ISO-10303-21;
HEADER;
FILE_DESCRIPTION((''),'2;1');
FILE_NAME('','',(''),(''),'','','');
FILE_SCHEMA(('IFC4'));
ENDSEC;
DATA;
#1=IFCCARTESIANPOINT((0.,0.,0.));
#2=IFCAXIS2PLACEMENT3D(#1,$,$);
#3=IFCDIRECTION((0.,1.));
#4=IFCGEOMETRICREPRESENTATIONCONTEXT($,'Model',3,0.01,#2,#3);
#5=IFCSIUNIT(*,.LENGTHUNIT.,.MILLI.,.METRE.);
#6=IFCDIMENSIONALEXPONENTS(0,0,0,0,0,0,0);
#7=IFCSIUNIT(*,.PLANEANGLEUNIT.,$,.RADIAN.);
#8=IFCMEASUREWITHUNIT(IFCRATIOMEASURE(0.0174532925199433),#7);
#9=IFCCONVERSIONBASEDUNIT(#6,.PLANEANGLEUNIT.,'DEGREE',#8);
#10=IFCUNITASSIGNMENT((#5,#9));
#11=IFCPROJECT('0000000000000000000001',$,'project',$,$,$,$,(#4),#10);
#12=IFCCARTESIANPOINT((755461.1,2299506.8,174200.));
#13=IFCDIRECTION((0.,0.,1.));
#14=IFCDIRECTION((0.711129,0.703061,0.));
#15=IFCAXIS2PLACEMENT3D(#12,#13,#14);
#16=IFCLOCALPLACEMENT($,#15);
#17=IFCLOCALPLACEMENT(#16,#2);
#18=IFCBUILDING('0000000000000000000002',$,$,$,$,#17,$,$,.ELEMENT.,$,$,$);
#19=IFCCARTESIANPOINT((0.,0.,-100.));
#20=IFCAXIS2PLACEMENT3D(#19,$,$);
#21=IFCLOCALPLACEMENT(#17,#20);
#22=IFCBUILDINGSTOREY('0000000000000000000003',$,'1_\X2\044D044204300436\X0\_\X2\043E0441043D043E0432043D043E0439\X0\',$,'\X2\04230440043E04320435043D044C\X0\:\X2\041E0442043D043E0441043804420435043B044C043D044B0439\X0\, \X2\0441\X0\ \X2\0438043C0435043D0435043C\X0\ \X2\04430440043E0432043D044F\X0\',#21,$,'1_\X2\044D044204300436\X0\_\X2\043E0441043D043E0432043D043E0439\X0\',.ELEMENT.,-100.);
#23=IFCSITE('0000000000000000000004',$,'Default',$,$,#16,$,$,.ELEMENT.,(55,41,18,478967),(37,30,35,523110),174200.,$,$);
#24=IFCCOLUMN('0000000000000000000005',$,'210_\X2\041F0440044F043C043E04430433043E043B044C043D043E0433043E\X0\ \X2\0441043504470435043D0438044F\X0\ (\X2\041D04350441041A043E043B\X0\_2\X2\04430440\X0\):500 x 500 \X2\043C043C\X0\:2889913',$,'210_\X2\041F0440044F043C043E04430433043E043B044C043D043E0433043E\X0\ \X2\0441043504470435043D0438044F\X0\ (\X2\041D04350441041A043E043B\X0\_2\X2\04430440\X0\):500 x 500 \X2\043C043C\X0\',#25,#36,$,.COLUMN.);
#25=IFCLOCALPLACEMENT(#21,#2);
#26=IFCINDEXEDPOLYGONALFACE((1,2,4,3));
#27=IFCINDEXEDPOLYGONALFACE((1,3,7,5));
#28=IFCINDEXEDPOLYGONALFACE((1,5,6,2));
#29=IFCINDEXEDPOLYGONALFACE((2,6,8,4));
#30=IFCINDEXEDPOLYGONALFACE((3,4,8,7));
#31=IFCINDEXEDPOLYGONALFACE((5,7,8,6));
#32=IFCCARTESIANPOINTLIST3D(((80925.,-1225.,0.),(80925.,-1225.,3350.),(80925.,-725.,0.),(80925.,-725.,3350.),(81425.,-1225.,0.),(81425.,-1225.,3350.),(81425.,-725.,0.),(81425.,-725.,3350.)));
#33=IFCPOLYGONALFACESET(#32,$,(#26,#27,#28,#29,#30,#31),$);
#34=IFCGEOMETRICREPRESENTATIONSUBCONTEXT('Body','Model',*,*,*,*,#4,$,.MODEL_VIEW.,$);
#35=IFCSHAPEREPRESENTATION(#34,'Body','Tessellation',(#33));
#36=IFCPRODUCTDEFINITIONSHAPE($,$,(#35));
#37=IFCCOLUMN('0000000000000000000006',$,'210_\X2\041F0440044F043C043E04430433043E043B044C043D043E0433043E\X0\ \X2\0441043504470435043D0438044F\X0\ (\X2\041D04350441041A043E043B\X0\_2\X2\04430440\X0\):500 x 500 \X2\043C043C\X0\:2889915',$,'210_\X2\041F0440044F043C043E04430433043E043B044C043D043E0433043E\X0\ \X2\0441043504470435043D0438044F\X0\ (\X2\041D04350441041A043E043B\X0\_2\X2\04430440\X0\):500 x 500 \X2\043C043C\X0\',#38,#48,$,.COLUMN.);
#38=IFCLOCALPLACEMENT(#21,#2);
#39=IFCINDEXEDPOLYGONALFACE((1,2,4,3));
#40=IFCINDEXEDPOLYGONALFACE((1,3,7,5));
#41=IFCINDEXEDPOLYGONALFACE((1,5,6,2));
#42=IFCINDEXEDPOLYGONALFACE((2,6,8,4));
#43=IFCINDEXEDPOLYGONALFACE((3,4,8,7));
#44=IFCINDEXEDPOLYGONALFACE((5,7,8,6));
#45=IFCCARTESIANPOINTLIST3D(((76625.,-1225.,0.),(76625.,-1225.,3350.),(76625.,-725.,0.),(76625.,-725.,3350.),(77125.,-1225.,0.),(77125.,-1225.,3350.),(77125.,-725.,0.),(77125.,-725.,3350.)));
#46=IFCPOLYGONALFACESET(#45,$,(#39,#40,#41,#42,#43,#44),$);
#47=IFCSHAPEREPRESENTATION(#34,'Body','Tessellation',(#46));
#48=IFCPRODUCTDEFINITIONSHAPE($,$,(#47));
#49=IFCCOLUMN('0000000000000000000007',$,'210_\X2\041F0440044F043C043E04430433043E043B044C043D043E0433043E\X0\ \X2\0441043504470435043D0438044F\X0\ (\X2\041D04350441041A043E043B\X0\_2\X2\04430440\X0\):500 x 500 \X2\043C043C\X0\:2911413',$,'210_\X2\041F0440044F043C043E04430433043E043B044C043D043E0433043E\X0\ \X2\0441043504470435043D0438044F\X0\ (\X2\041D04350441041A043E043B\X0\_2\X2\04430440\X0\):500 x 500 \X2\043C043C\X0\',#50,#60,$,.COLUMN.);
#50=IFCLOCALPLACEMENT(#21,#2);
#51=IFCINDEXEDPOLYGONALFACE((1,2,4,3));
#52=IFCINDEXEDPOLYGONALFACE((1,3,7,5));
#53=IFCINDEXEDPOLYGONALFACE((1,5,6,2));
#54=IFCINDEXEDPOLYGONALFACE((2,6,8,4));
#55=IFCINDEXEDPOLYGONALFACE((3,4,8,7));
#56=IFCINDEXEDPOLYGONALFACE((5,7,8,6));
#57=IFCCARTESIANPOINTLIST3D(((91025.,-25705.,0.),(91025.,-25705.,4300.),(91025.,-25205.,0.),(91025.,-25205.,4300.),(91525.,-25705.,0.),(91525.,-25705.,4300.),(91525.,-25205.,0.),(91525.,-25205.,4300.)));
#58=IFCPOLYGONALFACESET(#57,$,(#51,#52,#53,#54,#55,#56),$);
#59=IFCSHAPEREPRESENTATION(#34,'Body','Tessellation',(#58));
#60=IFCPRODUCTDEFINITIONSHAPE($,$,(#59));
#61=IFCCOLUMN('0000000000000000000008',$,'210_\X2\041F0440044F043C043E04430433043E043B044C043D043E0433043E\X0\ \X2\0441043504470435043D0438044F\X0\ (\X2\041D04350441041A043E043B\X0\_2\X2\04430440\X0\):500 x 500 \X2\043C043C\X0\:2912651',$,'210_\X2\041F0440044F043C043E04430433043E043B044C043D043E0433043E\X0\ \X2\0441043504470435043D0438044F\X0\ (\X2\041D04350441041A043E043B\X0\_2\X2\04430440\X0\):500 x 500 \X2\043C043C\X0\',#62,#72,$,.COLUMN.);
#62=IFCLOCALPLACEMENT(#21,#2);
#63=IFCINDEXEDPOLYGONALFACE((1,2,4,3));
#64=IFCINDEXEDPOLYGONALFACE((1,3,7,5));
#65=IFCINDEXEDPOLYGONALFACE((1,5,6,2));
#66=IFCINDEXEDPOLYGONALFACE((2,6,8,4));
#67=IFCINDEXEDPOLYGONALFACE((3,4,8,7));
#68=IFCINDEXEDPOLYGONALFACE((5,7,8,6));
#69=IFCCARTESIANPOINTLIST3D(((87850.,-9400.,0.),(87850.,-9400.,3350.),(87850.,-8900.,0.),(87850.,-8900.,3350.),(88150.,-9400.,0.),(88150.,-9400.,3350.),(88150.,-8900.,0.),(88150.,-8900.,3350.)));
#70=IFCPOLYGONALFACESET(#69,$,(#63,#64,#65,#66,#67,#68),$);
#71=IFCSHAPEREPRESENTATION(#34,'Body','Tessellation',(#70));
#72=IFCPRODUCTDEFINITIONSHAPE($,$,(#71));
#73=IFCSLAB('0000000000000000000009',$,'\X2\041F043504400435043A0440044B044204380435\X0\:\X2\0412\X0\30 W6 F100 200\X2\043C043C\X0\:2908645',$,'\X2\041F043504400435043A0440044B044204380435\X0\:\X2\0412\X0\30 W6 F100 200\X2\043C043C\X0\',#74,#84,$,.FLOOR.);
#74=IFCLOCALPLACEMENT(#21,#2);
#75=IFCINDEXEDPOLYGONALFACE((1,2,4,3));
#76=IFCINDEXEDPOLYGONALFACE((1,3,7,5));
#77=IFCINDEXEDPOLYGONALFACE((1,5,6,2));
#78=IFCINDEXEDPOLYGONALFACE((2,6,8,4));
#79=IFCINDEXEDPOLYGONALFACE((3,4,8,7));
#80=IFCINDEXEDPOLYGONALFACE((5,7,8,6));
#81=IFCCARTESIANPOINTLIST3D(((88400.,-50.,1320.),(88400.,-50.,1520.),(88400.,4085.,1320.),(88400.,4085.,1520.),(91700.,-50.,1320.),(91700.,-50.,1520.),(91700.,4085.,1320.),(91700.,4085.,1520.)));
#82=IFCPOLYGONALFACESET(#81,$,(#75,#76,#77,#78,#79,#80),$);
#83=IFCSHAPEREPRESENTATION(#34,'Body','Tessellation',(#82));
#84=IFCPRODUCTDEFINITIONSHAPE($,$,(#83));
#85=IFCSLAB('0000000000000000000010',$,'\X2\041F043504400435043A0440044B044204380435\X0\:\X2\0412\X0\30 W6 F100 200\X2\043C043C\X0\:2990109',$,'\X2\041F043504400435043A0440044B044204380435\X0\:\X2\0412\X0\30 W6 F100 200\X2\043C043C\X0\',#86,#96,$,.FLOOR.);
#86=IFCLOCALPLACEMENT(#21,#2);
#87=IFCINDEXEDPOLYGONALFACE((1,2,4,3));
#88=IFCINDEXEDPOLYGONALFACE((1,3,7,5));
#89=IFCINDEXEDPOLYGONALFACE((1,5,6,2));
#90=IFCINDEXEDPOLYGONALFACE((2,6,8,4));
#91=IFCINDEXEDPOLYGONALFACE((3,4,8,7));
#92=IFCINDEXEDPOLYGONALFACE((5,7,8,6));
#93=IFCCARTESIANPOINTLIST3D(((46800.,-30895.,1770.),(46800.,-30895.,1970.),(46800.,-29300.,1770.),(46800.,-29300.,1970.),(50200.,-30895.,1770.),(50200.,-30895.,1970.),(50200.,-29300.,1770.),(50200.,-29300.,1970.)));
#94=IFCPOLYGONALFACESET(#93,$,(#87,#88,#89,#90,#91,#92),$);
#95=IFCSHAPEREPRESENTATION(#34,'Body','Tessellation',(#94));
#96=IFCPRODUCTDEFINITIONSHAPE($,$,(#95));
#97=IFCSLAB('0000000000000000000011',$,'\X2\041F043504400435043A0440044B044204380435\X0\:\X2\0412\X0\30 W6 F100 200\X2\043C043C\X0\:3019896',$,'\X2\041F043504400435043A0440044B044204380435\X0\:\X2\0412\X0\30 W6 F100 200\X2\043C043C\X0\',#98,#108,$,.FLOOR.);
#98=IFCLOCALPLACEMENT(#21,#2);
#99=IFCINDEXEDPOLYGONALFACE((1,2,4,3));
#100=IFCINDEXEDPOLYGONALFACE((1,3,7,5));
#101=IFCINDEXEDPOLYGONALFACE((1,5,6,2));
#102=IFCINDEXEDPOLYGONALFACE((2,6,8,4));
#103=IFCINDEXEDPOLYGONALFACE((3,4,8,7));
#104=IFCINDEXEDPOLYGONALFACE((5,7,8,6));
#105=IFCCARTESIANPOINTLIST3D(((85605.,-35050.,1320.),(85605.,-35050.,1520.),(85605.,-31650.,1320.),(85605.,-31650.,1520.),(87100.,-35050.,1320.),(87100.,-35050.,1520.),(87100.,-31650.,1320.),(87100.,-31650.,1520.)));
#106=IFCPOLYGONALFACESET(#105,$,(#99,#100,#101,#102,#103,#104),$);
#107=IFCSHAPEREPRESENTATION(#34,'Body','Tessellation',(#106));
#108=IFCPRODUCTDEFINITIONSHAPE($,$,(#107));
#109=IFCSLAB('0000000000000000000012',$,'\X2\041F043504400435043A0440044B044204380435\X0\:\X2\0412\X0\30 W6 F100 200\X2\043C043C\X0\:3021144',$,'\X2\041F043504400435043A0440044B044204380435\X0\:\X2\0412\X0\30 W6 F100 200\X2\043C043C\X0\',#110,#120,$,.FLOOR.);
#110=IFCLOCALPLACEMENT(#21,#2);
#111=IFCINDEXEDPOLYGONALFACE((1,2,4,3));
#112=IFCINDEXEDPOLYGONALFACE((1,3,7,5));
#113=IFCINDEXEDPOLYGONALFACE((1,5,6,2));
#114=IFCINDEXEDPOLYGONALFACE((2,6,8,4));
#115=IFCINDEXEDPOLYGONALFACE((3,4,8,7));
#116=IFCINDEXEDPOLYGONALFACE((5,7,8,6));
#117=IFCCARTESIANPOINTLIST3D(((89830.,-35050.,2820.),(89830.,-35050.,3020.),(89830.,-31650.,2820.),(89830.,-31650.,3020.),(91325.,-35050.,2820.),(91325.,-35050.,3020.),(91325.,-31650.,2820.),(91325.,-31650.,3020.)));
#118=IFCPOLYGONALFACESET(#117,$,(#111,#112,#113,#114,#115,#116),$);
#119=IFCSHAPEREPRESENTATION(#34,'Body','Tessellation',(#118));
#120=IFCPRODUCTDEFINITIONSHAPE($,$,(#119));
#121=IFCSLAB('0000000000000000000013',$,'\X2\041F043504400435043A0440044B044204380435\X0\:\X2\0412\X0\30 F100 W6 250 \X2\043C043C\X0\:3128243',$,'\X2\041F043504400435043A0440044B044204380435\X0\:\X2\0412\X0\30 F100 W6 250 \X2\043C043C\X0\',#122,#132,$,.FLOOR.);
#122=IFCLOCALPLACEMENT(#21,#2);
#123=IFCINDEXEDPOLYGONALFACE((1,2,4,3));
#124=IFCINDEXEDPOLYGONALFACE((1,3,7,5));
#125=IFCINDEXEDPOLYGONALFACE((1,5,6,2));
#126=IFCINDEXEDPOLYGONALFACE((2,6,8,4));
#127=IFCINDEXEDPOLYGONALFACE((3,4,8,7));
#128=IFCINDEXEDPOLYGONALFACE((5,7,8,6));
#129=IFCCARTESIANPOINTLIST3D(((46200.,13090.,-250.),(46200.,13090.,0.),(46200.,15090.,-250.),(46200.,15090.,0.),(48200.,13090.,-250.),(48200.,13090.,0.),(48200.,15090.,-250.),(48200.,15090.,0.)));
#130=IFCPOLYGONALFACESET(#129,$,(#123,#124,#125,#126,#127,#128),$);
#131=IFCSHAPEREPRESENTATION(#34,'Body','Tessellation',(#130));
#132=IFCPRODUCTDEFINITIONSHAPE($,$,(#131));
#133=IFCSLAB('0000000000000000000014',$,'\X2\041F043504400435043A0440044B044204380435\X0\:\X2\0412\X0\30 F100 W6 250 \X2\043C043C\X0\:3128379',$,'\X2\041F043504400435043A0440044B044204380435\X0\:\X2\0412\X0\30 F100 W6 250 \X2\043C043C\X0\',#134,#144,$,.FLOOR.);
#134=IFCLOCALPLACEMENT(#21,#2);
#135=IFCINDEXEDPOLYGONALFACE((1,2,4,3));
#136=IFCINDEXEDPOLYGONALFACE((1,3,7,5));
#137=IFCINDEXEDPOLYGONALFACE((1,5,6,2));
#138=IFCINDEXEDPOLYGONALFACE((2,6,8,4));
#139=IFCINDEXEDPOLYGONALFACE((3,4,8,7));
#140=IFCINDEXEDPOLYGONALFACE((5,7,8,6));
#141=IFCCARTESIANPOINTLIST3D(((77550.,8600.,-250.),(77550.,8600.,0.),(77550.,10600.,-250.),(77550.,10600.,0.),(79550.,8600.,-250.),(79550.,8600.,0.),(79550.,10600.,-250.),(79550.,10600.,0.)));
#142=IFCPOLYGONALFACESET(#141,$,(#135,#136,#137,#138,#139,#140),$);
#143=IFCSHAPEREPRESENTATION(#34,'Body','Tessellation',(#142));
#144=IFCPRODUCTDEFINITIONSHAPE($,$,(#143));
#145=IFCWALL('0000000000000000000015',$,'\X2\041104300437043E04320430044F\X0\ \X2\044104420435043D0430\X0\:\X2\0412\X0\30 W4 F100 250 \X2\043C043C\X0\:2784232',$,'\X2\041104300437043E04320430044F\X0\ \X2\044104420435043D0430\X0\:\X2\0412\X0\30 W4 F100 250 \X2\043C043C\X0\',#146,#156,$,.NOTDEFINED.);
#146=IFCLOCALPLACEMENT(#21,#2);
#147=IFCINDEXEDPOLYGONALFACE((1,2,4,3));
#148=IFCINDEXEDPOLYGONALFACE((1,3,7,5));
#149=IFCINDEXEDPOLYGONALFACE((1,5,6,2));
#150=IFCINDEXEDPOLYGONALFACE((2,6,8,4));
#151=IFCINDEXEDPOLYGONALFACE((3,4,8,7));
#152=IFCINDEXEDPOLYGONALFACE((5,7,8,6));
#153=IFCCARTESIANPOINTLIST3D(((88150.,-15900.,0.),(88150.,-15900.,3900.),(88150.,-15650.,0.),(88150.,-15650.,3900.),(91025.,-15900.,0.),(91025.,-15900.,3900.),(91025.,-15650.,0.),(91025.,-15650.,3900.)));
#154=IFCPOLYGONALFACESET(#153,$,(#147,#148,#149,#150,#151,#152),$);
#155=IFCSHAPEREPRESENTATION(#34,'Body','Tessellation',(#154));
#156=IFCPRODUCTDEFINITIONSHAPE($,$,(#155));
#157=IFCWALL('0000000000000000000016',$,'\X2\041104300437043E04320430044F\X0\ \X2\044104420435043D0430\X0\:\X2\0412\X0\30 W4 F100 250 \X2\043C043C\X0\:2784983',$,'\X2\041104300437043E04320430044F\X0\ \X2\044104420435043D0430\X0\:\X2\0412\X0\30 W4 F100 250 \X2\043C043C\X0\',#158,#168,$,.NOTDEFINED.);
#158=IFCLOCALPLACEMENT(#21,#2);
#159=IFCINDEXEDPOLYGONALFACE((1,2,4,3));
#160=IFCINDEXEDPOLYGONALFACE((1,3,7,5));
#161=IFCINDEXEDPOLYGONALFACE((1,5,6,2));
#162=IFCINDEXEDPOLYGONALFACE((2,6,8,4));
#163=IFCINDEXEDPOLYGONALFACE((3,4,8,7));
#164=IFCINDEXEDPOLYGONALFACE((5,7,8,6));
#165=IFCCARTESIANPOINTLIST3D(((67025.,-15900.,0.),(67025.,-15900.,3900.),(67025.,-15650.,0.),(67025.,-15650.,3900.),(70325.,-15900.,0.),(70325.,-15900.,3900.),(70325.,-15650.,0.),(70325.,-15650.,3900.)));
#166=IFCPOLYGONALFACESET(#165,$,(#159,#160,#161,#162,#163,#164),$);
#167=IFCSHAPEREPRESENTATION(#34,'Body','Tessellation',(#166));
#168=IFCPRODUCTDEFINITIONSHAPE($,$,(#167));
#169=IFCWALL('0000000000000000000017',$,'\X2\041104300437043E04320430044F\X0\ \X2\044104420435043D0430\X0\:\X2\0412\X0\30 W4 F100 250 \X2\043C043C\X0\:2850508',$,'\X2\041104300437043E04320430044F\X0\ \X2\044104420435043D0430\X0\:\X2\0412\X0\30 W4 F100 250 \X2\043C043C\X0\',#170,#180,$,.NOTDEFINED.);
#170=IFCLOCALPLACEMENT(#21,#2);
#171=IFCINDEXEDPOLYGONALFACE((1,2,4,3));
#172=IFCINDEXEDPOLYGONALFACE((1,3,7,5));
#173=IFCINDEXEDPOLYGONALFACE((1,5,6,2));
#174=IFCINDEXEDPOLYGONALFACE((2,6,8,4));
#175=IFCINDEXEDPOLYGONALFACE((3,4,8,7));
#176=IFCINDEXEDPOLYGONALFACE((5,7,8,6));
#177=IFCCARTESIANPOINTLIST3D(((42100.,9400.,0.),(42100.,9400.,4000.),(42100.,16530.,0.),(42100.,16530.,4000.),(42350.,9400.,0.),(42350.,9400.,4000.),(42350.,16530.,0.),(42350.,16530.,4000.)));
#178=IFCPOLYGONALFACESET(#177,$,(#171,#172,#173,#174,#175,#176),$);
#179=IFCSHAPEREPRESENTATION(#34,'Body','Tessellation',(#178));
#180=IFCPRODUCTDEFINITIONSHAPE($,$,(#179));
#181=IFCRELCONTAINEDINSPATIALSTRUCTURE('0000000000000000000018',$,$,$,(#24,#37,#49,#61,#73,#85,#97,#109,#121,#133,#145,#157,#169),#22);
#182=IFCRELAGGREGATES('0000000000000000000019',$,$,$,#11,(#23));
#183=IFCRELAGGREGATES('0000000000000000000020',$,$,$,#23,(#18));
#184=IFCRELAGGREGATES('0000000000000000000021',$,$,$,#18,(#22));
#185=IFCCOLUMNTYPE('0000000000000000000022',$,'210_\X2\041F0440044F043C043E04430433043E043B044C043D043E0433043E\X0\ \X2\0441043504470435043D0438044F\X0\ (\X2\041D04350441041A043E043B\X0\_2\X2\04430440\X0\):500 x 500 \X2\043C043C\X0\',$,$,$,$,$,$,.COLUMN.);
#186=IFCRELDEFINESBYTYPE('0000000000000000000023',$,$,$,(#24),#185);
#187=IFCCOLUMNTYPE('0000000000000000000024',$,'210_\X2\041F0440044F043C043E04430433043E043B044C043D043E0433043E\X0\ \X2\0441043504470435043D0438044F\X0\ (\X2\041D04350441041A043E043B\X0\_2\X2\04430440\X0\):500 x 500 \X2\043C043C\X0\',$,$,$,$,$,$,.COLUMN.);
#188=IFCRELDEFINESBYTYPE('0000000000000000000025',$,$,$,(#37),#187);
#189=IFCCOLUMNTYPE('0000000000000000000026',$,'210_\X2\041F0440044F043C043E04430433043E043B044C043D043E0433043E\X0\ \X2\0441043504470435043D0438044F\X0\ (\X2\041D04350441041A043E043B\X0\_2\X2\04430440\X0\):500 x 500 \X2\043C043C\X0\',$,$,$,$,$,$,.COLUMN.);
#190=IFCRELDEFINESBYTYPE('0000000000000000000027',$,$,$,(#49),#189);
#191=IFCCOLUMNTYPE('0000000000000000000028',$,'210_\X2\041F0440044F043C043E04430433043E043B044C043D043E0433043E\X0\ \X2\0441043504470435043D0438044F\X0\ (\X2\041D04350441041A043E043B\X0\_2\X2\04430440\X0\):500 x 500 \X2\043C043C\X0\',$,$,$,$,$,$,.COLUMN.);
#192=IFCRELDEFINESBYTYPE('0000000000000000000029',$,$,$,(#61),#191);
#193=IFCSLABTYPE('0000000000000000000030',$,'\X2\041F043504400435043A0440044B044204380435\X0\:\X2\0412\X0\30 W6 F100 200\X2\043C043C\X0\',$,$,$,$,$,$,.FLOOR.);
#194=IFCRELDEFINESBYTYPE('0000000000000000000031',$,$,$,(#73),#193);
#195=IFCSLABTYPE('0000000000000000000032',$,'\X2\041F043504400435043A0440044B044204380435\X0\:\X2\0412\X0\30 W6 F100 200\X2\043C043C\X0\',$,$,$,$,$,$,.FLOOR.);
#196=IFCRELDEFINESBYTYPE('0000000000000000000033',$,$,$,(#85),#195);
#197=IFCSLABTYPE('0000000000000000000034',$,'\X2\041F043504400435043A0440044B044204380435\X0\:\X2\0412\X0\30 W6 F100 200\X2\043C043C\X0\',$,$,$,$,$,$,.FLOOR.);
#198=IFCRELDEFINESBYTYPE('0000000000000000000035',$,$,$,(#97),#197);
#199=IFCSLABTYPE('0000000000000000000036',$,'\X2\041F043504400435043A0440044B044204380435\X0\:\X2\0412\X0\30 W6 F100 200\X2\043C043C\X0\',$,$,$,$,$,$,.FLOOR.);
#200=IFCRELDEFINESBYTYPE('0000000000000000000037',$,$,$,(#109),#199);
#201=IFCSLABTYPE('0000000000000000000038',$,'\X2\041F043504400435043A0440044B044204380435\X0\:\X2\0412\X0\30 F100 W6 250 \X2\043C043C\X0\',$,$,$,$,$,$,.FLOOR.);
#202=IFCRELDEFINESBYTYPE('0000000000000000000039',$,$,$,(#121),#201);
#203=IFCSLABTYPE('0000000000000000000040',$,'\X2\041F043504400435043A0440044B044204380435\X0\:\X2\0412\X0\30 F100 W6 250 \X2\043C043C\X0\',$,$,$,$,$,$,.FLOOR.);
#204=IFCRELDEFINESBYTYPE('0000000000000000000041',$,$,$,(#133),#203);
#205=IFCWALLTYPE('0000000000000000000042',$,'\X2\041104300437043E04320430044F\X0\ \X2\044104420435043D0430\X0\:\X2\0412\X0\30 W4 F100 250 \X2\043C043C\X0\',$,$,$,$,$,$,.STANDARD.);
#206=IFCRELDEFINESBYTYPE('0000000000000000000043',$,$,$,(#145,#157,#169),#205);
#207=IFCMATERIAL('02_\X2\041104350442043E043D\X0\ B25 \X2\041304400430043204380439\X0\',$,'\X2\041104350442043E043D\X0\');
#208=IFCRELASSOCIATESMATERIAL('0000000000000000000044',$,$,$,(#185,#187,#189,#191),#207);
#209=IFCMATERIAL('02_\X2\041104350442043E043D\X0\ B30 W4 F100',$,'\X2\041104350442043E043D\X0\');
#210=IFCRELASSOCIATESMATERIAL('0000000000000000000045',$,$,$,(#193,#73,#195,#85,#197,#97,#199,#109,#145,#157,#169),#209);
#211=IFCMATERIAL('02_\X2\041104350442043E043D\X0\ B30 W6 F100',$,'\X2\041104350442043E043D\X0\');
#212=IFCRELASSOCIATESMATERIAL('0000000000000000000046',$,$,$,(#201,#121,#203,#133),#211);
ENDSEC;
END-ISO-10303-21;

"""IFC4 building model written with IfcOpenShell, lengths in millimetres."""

from ifc_helpers import new_model, entity, si_unit, converted_unit, direction, frame, origin, place, context, subcontext, project, spatial, indexed_curve, outline, extrude, source, transform, mapped, material, type_object, type_shapes, element, save


model = new_model("IFC4")

# Units and contexts
model_context = context("Model", 3, precision=0.01, world=origin(), true_north=direction((0.0, 1.0)))
body_context = subcontext(model_context, "Body", "Model", "MODEL_VIEW")
ifc_project = project(units=[si_unit("LENGTHUNIT", "METRE", prefix="MILLI"), converted_unit("PLANEANGLEUNIT", "DEGREE", entity("IfcRatioMeasure", 0.0174532925199433), si_unit("PLANEANGLEUNIT", "RADIAN"), dimensions=[0, 0, 0, 0, 0, 0, 0])], contexts=[model_context])

# Site, building, storey
site_placement = place(None, frame((755461.1, 2299506.8, 174200.0), z_axis=(0.0, 0.0, 1.0), x_axis=(0.711129, 0.703061, 0.0)))
site = spatial("IfcSite", under=ifc_project, at=site_placement, Name="Default", CompositionType="ELEMENT", RefLatitude=(55, 41, 18, 478967), RefLongitude=(37, 30, 35, 523110), RefElevation=174200.0)
building_placement = place(site_placement, origin())
building = spatial("IfcBuilding", under=site, at=building_placement, CompositionType="ELEMENT")
storey_placement = place(building_placement, frame((0.0, 0.0, -100.0)))
storey = spatial("IfcBuildingStorey", under=building, at=storey_placement, Name="1_этаж_основной", ObjectType="Уровень:Относительный, с именем уровня", LongName="1_этаж_основной", CompositionType="ELEMENT", Elevation=-100.0)

# Columns
ifc_material_1 = material(Name="02_Бетон B25 Гравий", Category="Бетон")
column_type_1 = type_object("IfcColumnType", Name="210_Прямоугольного сечения (НесКол_2ур):500 x 500 мм", PredefinedType="COLUMN", material=ifc_material_1)
shared_shape_1 = source(origin(), body_context, "Body", "SweptSolid", [
    extrude(outline(indexed_curve([(-250.0, -250.0), (250.0, -250.0), (250.0, 250.0), (-250.0, 250.0), (-250.0, -250.0)], self_intersect=False)), frame((81175.0, -975.0, -100.0), z_axis=(0.0, 0.0, 1.0), x_axis=(0.0, -1.0, 0.0)), (0.0, 0.0, 1.0), 3350.0),
])
type_shapes(column_type_1, [shared_shape_1])
column_1_placement = place(storey_placement, frame((0.0, 0.0, 100.0)))
element("IfcColumn", 1, at=column_1_placement, inside=storey, type_object=column_type_1, Name="210_Прямоугольного сечения (НесКол_2ур):500 x 500 мм:2889913", ObjectType="210_Прямоугольного сечения (НесКол_2ур):500 x 500 мм", PredefinedType="COLUMN", context=body_context, shape_type="MappedRepresentation", body=[
    mapped(shared_shape_1, transform((0.0, 0.0, 0.0), scale=1.0)),
])
column_type_2 = type_object("IfcColumnType", Name="210_Прямоугольного сечения (НесКол_2ур):500 x 500 мм", PredefinedType="COLUMN", material=ifc_material_1)
shared_shape_2 = source(origin(), body_context, "Body", "SweptSolid", [
    extrude(outline(indexed_curve([(-250.0, -250.0), (250.0, -250.0), (250.0, 250.0), (-250.0, 250.0), (-250.0, -250.0)], self_intersect=False)), frame((76875.0, -975.0, -100.0), z_axis=(0.0, 0.0, 1.0), x_axis=(0.0, -1.0, 0.0)), (0.0, 0.0, 1.0), 3350.0),
])
type_shapes(column_type_2, [shared_shape_2])
column_2_placement = place(storey_placement, frame((0.0, 0.0, 100.0)))
element("IfcColumn", 2, at=column_2_placement, inside=storey, type_object=column_type_2, Name="210_Прямоугольного сечения (НесКол_2ур):500 x 500 мм:2889915", ObjectType="210_Прямоугольного сечения (НесКол_2ур):500 x 500 мм", PredefinedType="COLUMN", context=body_context, shape_type="MappedRepresentation", body=[
    mapped(shared_shape_2, transform((0.0, 0.0, 0.0), scale=1.0)),
])
column_type_3 = type_object("IfcColumnType", Name="210_Прямоугольного сечения (НесКол_2ур):500 x 500 мм", PredefinedType="COLUMN", material=ifc_material_1)
shared_shape_3 = source(origin(), body_context, "Body", "SweptSolid", [
    extrude(outline(indexed_curve([(-250.0, -250.0), (250.0, -250.0), (250.0, 250.0), (-250.0, 250.0), (-250.0, -250.0)], self_intersect=False)), frame((91275.0, -25455.0, -100.0), z_axis=(0.0, 0.0, 1.0), x_axis=(0.0, -1.0, 0.0)), (0.0, 0.0, 1.0), 4300.0),
])
type_shapes(column_type_3, [shared_shape_3])
column_3_placement = place(storey_placement, frame((0.0, 0.0, 100.0)))
element("IfcColumn", 3, at=column_3_placement, inside=storey, type_object=column_type_3, Name="210_Прямоугольного сечения (НесКол_2ур):500 x 500 мм:2911413", ObjectType="210_Прямоугольного сечения (НесКол_2ур):500 x 500 мм", PredefinedType="COLUMN", context=body_context, shape_type="MappedRepresentation", body=[
    mapped(shared_shape_3, transform((0.0, 0.0, 0.0), scale=1.0)),
])
column_type_4 = type_object("IfcColumnType", Name="210_Прямоугольного сечения (НесКол_2ур):500 x 500 мм", PredefinedType="COLUMN", material=ifc_material_1)
shared_shape_4 = source(origin(), body_context, "Body", "SweptSolid", [
    extrude(outline(indexed_curve([(-250.0, -150.0), (250.0, -150.0), (250.0, 150.0), (-250.0, 150.0), (-250.0, -150.0)], self_intersect=False)), frame((88000.0, -9150.0, -100.0), z_axis=(0.0, 0.0, 1.0), x_axis=(0.0, -1.0, 0.0)), (0.0, 0.0, 1.0), 3350.0),
])
type_shapes(column_type_4, [shared_shape_4])
column_4_placement = place(storey_placement, frame((0.0, 0.0, 100.0)))
element("IfcColumn", 4, at=column_4_placement, inside=storey, type_object=column_type_4, Name="210_Прямоугольного сечения (НесКол_2ур):500 x 500 мм:2912651", ObjectType="210_Прямоугольного сечения (НесКол_2ур):500 x 500 мм", PredefinedType="COLUMN", context=body_context, shape_type="MappedRepresentation", body=[
    mapped(shared_shape_4, transform((0.0, 0.0, 0.0), scale=1.0)),
])

# Slabs
ifc_material_2 = material(Name="02_Бетон B30 W4 F100", Category="Бетон")
slab_type_1 = type_object("IfcSlabType", Name="Перекрытие:В30 W6 F100 200мм", PredefinedType="FLOOR", material=ifc_material_2)
slab_1_placement = place(storey_placement, origin())
element("IfcSlab", 5, at=slab_1_placement, inside=storey, type_object=slab_type_1, material=ifc_material_2, Name="Перекрытие:В30 W6 F100 200мм:2908645", ObjectType="Перекрытие:В30 W6 F100 200мм", PredefinedType="FLOOR", context=body_context, shape_type="SweptSolid", body=[
    extrude(outline(indexed_curve([(-2067.5, -1650.0), (2067.5, -1650.0), (2067.5, 1650.0), (-2067.5, 1650.0), (-2067.5, -1650.0)], self_intersect=False)), frame((90050.0, 2017.5, 1520.0), z_axis=(0.0, 0.0, -1.0), x_axis=(0.0, 1.0, 0.0)), (0.0, 0.0, 1.0), 200.0),
])
slab_type_2 = type_object("IfcSlabType", Name="Перекрытие:В30 W6 F100 200мм", PredefinedType="FLOOR", material=ifc_material_2)
slab_2_placement = place(storey_placement, origin())
element("IfcSlab", 6, at=slab_2_placement, inside=storey, type_object=slab_type_2, material=ifc_material_2, Name="Перекрытие:В30 W6 F100 200мм:2990109", ObjectType="Перекрытие:В30 W6 F100 200мм", PredefinedType="FLOOR", context=body_context, shape_type="SweptSolid", body=[
    extrude(outline(indexed_curve([(-797.5, -1700.0), (797.5, -1700.0), (797.5, 1700.0), (-797.5, 1700.0), (-797.5, -1700.0)], self_intersect=False)), frame((48500.0, -30097.5, 1970.0), z_axis=(0.0, 0.0, -1.0), x_axis=(0.0, 1.0, 0.0)), (0.0, 0.0, 1.0), 200.0),
])
slab_type_3 = type_object("IfcSlabType", Name="Перекрытие:В30 W6 F100 200мм", PredefinedType="FLOOR", material=ifc_material_2)
slab_3_placement = place(storey_placement, origin())
element("IfcSlab", 7, at=slab_3_placement, inside=storey, type_object=slab_type_3, material=ifc_material_2, Name="Перекрытие:В30 W6 F100 200мм:3019896", ObjectType="Перекрытие:В30 W6 F100 200мм", PredefinedType="FLOOR", context=body_context, shape_type="SweptSolid", body=[
    extrude(outline(indexed_curve([(-1700.0, -747.5), (1700.0, -747.5), (1700.0, 747.5), (-1700.0, 747.5), (-1700.0, -747.5)], self_intersect=False)), frame((86352.5, -33350.0, 1520.0), z_axis=(0.0, 0.0, -1.0), x_axis=(0.0, 1.0, 0.0)), (0.0, 0.0, 1.0), 200.0),
])
slab_type_4 = type_object("IfcSlabType", Name="Перекрытие:В30 W6 F100 200мм", PredefinedType="FLOOR", material=ifc_material_2)
slab_4_placement = place(storey_placement, origin())
element("IfcSlab", 8, at=slab_4_placement, inside=storey, type_object=slab_type_4, material=ifc_material_2, Name="Перекрытие:В30 W6 F100 200мм:3021144", ObjectType="Перекрытие:В30 W6 F100 200мм", PredefinedType="FLOOR", context=body_context, shape_type="SweptSolid", body=[
    extrude(outline(indexed_curve([(-1700.0, -747.5), (1700.0, -747.5), (1700.0, 747.5), (-1700.0, 747.5), (-1700.0, -747.5)], self_intersect=False)), frame((90577.5, -33350.0, 3020.0), z_axis=(0.0, 0.0, -1.0), x_axis=(0.0, 1.0, 0.0)), (0.0, 0.0, 1.0), 200.0),
])
ifc_material_3 = material(Name="02_Бетон B30 W6 F100", Category="Бетон")
slab_type_5 = type_object("IfcSlabType", Name="Перекрытие:В30 F100 W6 250 мм", PredefinedType="FLOOR", material=ifc_material_3)
slab_5_placement = place(storey_placement, origin())
element("IfcSlab", 9, at=slab_5_placement, inside=storey, type_object=slab_type_5, material=ifc_material_3, Name="Перекрытие:В30 F100 W6 250 мм:3128243", ObjectType="Перекрытие:В30 F100 W6 250 мм", PredefinedType="FLOOR", context=body_context, shape_type="SweptSolid", body=[
    extrude(outline(indexed_curve([(-1000.0, -1000.0), (1000.0, -1000.0), (1000.0, 1000.0), (-1000.0, 1000.0), (-1000.0, -1000.0)], self_intersect=False)), frame((47200.0, 14090.0, 0.0), z_axis=(0.0, 0.0, -1.0), x_axis=(0.0, 1.0, 0.0)), (0.0, 0.0, 1.0), 250.0),
])
slab_type_6 = type_object("IfcSlabType", Name="Перекрытие:В30 F100 W6 250 мм", PredefinedType="FLOOR", material=ifc_material_3)
slab_6_placement = place(storey_placement, origin())
element("IfcSlab", 10, at=slab_6_placement, inside=storey, type_object=slab_type_6, material=ifc_material_3, Name="Перекрытие:В30 F100 W6 250 мм:3128379", ObjectType="Перекрытие:В30 F100 W6 250 мм", PredefinedType="FLOOR", context=body_context, shape_type="SweptSolid", body=[
    extrude(outline(indexed_curve([(-1000.0, -1000.0), (1000.0, -1000.0), (1000.0, 1000.0), (-1000.0, 1000.0), (-1000.0, -1000.0)], self_intersect=False)), frame((78550.0, 9600.0, 0.0), z_axis=(0.0, 0.0, -1.0), x_axis=(0.0, 1.0, 0.0)), (0.0, 0.0, 1.0), 250.0),
])

# Walls
wall_type_1 = type_object("IfcWallType", Name="Базовая стена:В30 W4 F100 250 мм", PredefinedType="STANDARD")
wall_1_placement = place(storey_placement, frame((91025.0, -15775.0, 0.0), z_axis=(0.0, 0.0, 1.0), x_axis=(-1.0, 0.0, 0.0)))
element("IfcWall", 11, at=wall_1_placement, inside=storey, type_object=wall_type_1, material=ifc_material_2, Name="Базовая стена:В30 W4 F100 250 мм:2784232", ObjectType="Базовая стена:В30 W4 F100 250 мм", PredefinedType="NOTDEFINED", context=body_context, shape_type="SweptSolid", body=[
    extrude(outline(indexed_curve([(2875.0, 125.0), (0.0, 125.0), (0.0, -125.0), (2875.0, -125.0), (2875.0, 125.0)], self_intersect=False)), origin(), (0.0, 0.0, 1.0), 3900.0),
])
wall_2_placement = place(storey_placement, frame((70325.0, -15775.0, 0.0), z_axis=(0.0, 0.0, 1.0), x_axis=(-1.0, 0.0, 0.0)))
element("IfcWall", 12, at=wall_2_placement, inside=storey, type_object=wall_type_1, material=ifc_material_2, Name="Базовая стена:В30 W4 F100 250 мм:2784983", ObjectType="Базовая стена:В30 W4 F100 250 мм", PredefinedType="NOTDEFINED", context=body_context, shape_type="SweptSolid", body=[
    extrude(outline(indexed_curve([(3300.0, 125.0), (0.0, 125.0), (0.0, -125.0), (3300.0, -125.0), (3300.0, 125.0)], self_intersect=False)), origin(), (0.0, 0.0, 1.0), 3900.0),
])
wall_3_placement = place(storey_placement, frame((42225.0, 9400.0, 0.0), z_axis=(0.0, 0.0, 1.0), x_axis=(0.0, 1.0, 0.0)))
element("IfcWall", 13, at=wall_3_placement, inside=storey, type_object=wall_type_1, material=ifc_material_2, Name="Базовая стена:В30 W4 F100 250 мм:2850508", ObjectType="Базовая стена:В30 W4 F100 250 мм", PredefinedType="NOTDEFINED", context=body_context, shape_type="SweptSolid", body=[
    extrude(outline(indexed_curve([(7130.0, 125.0), (0.0, 125.0), (0.0, -125.0), (7130.0, -125.0), (7130.0, 125.0)], self_intersect=False)), origin(), (0.0, 0.0, 1.0), 4000.0),
])

save(model, "model.ifc")
